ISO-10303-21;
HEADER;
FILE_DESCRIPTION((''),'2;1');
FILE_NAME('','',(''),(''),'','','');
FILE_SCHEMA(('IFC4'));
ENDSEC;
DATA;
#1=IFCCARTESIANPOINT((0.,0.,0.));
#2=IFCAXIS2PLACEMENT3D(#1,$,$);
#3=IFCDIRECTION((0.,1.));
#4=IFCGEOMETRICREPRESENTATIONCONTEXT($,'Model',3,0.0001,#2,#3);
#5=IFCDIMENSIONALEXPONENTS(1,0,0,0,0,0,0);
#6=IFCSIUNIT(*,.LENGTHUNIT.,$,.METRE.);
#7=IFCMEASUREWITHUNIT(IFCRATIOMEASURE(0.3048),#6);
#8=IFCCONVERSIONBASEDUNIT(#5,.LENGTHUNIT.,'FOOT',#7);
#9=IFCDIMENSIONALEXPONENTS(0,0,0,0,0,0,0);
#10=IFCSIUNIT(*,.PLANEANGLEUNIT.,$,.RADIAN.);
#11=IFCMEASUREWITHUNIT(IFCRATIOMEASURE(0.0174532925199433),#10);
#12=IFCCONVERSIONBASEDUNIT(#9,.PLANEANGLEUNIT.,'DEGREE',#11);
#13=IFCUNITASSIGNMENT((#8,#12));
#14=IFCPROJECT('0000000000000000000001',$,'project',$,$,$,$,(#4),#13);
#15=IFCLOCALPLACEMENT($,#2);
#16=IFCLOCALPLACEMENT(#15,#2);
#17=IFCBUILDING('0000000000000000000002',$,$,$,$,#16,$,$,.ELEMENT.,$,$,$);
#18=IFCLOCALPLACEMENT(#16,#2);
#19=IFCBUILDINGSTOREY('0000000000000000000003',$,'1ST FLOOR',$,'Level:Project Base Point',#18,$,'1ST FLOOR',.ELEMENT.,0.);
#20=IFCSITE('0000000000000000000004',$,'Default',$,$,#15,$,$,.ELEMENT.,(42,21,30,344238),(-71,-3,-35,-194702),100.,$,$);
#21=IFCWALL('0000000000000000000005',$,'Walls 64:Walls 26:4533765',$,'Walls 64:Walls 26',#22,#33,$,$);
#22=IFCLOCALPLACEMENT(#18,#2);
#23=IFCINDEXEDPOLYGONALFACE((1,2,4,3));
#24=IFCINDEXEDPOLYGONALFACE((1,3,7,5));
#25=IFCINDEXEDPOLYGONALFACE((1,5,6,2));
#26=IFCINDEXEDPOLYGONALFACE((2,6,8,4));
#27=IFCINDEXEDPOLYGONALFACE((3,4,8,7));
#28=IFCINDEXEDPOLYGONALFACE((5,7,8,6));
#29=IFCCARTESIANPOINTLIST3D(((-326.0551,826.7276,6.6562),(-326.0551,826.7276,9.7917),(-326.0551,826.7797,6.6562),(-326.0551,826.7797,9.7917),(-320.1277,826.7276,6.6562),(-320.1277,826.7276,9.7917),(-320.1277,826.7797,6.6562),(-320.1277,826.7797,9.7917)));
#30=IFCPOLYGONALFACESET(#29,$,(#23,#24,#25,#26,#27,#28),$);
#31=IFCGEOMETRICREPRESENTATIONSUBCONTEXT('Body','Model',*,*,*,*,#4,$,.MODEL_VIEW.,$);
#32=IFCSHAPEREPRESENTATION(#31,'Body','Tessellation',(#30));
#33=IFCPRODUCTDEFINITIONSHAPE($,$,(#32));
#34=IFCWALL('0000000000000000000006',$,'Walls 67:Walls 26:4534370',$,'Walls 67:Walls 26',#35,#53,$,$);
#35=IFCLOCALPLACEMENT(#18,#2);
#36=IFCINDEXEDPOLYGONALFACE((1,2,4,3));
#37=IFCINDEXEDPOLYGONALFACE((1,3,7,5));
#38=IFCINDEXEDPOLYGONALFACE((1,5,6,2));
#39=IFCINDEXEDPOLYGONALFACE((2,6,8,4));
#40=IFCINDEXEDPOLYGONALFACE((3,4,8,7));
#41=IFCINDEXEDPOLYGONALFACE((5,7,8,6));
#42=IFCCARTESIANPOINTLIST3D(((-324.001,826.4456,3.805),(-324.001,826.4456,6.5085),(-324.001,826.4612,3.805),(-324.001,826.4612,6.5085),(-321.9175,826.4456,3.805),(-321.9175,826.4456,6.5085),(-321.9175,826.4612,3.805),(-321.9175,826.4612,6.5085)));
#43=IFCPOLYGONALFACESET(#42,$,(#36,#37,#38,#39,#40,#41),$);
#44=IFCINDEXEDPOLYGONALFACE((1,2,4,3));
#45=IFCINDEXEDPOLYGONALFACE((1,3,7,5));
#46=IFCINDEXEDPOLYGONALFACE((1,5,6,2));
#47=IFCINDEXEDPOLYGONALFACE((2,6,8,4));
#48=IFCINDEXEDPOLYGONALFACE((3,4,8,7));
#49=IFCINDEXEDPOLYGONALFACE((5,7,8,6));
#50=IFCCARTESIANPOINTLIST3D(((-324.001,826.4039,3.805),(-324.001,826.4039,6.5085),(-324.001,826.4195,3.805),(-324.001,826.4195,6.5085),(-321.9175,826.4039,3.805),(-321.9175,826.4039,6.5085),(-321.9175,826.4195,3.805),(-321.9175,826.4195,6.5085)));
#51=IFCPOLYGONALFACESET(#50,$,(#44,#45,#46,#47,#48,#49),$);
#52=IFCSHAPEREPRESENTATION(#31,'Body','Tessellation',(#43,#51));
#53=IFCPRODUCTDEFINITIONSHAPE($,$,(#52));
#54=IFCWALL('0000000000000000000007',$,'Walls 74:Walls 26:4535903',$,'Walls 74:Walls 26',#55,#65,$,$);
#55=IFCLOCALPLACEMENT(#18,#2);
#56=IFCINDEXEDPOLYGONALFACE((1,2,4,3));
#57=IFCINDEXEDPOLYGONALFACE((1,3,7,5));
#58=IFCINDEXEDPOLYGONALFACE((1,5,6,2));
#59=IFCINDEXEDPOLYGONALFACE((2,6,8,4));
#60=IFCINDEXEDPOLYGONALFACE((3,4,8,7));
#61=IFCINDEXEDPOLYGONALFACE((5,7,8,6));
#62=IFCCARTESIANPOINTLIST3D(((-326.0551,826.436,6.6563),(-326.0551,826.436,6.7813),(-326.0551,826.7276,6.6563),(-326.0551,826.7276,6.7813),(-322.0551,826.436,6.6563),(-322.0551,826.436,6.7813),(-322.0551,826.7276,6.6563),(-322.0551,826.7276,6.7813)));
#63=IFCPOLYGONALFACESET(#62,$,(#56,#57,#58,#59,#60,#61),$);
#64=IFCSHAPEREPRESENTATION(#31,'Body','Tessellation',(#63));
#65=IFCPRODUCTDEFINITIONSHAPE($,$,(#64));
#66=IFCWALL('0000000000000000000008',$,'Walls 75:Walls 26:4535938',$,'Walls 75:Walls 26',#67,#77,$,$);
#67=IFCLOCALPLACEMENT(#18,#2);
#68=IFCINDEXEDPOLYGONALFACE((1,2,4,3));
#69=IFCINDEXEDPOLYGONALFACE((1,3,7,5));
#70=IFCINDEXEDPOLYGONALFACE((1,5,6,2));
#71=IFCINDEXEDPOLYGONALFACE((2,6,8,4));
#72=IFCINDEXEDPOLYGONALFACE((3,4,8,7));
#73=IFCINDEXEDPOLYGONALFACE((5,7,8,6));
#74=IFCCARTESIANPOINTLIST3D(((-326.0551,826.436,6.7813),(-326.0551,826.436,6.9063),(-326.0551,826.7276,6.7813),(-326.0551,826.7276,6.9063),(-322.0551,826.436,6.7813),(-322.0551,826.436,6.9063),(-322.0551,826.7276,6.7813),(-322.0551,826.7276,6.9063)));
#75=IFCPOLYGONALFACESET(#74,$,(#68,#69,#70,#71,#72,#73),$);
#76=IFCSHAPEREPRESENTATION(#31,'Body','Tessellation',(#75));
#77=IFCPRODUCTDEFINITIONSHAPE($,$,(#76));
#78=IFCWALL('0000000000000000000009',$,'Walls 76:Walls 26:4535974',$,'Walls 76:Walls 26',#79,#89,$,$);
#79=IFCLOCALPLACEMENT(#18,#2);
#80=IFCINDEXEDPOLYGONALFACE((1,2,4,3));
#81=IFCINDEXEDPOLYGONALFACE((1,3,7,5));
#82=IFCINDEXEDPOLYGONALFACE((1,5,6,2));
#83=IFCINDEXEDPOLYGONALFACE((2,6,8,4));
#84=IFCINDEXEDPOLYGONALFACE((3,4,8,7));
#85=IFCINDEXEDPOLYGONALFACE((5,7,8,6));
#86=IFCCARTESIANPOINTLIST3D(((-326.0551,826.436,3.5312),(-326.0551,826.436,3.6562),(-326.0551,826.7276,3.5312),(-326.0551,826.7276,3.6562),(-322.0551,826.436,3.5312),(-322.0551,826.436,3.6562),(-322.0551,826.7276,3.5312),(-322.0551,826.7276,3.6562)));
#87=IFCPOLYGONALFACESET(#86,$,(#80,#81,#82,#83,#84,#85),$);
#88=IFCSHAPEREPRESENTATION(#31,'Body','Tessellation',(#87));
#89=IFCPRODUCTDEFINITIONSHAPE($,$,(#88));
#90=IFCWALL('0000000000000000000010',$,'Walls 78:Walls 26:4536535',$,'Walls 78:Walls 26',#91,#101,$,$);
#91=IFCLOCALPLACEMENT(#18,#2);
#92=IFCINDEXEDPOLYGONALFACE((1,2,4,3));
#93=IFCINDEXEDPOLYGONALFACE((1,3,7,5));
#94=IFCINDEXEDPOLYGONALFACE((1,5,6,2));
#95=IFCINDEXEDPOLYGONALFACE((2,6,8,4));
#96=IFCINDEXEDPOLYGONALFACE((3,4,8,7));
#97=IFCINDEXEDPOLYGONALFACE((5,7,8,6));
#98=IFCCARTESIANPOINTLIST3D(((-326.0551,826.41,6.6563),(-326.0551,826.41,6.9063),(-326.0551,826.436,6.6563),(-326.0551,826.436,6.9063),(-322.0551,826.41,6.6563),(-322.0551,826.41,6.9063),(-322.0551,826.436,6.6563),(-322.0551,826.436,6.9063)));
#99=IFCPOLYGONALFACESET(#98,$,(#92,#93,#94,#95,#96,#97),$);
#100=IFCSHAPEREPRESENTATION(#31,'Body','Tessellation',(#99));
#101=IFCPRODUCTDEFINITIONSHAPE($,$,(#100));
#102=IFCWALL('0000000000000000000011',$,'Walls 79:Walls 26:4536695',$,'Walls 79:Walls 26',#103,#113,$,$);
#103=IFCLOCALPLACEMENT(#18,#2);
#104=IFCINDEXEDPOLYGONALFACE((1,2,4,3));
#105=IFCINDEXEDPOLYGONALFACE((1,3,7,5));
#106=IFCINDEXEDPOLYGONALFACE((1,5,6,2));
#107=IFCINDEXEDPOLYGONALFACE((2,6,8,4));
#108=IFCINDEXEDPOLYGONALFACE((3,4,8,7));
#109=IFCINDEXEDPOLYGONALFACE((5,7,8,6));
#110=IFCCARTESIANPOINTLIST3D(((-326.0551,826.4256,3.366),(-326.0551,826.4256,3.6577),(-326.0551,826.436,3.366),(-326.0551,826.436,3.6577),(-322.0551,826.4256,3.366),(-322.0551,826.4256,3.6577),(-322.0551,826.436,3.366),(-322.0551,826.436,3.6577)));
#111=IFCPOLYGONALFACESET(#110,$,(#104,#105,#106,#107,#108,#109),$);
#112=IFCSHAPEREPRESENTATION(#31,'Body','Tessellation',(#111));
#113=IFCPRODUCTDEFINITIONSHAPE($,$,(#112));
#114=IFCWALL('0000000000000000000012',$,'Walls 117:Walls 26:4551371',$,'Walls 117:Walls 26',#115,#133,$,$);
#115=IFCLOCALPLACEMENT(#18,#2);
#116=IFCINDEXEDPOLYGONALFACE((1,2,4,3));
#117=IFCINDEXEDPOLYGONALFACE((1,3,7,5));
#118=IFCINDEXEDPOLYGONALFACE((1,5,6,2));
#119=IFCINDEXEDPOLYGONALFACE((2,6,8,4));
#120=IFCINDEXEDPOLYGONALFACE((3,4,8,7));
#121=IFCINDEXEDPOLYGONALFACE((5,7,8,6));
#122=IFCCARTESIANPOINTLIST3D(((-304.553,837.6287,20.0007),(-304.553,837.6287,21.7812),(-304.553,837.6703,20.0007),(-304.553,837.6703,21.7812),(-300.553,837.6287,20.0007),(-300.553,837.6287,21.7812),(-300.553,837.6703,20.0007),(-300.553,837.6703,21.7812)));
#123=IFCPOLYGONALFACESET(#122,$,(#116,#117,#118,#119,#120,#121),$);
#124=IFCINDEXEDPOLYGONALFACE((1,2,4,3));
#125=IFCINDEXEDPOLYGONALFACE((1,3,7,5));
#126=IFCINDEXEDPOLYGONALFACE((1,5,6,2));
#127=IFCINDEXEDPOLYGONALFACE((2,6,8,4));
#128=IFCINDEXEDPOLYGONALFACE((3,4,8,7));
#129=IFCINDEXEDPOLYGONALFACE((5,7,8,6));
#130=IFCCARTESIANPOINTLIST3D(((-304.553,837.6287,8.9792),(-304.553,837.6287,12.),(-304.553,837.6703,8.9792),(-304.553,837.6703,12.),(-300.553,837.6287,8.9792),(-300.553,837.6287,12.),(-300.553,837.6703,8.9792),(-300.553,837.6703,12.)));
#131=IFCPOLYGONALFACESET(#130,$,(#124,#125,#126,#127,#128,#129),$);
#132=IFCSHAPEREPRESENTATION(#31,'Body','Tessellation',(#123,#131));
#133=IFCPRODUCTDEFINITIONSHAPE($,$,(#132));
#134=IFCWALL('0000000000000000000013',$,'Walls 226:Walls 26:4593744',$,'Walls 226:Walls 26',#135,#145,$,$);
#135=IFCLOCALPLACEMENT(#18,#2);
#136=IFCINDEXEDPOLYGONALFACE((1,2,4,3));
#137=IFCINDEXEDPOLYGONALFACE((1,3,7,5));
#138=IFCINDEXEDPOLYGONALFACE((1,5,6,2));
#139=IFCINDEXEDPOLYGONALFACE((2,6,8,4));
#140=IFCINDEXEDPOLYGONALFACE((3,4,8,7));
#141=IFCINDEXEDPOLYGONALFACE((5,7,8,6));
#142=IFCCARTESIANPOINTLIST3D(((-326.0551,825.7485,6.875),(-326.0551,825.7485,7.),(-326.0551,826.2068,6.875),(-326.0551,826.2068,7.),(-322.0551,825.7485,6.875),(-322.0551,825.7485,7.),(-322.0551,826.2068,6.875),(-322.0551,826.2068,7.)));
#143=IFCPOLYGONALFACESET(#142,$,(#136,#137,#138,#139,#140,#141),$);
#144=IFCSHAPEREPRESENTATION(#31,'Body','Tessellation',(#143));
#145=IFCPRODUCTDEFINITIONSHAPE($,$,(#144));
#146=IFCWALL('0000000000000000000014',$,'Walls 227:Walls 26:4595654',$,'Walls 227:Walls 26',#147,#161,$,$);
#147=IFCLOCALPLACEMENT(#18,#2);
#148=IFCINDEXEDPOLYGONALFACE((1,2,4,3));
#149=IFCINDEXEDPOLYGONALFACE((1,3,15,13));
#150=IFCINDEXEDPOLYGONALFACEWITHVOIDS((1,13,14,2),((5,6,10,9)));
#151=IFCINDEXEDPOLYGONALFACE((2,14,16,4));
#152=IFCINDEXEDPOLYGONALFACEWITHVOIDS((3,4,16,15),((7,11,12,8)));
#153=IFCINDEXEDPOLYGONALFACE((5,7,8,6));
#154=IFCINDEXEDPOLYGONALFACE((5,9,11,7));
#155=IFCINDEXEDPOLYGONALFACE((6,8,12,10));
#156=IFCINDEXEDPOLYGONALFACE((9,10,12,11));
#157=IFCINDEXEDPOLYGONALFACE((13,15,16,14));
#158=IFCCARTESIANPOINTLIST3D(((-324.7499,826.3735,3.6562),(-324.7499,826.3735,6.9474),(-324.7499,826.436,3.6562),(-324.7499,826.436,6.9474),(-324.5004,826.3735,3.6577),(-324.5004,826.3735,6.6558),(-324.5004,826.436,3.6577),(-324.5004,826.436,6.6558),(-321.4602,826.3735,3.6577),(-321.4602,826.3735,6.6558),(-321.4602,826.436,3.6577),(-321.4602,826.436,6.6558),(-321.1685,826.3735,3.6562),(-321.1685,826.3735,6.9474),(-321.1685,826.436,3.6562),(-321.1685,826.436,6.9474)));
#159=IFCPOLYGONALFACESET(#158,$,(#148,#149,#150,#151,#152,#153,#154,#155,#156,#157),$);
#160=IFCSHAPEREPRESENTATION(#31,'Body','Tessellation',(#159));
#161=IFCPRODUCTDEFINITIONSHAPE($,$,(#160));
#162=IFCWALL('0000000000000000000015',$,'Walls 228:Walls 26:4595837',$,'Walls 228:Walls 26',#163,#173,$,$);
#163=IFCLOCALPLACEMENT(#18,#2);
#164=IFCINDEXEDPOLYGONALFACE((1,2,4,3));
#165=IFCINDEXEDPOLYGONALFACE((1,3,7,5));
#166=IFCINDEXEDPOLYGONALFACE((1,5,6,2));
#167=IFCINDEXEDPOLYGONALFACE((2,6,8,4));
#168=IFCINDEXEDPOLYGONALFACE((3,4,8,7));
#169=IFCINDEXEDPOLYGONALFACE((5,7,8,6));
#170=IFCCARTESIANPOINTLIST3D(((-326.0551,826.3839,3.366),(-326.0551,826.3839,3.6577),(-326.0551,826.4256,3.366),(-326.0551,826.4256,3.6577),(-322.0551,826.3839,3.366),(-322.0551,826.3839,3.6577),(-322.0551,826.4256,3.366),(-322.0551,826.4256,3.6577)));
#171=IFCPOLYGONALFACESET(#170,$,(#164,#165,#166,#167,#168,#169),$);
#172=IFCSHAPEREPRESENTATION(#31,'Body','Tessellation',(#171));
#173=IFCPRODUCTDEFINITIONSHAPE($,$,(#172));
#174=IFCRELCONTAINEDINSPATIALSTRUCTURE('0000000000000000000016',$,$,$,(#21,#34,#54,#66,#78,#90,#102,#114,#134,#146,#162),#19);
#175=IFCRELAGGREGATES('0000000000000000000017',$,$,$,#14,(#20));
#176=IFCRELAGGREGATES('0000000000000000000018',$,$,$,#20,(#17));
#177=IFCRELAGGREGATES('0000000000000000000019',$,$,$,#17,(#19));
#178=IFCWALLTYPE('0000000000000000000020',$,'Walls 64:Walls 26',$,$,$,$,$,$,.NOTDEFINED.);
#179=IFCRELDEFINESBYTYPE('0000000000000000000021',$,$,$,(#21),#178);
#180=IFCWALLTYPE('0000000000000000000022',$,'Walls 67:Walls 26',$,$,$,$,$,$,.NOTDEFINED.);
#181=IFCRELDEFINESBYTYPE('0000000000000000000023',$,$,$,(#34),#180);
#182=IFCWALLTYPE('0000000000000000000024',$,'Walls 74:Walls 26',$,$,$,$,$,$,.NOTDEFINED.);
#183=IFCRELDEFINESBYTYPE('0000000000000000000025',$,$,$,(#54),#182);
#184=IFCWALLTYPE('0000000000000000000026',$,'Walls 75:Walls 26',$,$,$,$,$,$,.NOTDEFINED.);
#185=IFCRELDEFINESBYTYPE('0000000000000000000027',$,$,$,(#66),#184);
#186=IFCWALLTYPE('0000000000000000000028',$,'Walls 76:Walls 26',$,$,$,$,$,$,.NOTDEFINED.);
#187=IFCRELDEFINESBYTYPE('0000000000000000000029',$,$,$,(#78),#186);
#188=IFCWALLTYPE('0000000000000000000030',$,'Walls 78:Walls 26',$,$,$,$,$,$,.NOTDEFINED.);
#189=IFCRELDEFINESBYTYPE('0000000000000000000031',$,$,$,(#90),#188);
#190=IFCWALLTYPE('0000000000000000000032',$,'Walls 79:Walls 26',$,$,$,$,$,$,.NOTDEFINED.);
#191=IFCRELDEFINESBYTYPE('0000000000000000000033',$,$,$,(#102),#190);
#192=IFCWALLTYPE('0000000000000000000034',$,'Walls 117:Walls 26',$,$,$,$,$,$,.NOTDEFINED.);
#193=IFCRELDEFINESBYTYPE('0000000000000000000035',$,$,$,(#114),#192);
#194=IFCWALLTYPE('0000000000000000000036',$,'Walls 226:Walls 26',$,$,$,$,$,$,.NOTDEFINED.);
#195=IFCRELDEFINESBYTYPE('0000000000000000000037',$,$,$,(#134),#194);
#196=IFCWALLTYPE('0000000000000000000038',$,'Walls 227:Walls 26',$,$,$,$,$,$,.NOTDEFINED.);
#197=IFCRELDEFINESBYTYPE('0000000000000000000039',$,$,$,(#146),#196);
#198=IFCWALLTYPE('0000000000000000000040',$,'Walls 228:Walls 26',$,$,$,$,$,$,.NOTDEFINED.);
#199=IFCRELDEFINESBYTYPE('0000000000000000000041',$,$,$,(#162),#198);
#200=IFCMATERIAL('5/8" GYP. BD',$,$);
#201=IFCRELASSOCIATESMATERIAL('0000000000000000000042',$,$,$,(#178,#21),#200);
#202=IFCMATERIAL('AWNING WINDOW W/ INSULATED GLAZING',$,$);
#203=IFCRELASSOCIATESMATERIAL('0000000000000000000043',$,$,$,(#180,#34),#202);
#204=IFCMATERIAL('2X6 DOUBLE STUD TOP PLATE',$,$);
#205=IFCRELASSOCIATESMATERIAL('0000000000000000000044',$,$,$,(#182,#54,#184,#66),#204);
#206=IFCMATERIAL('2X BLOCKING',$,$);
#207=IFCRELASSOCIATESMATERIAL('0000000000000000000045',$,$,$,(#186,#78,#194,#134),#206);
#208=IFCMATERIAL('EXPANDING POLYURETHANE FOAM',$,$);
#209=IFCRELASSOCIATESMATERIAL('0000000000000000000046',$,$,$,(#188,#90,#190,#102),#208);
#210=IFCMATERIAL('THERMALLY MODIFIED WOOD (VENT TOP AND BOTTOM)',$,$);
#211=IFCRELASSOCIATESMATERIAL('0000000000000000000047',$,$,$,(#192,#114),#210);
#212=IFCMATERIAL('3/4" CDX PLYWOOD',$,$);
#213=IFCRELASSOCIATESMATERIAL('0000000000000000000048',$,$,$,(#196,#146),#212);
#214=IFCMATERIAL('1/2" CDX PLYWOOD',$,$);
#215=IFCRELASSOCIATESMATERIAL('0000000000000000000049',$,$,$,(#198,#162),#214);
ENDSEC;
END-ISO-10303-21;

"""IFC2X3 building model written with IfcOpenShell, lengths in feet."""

from ifc_helpers import new_model, entity, si_unit, converted_unit, direction, frame, frame_2d, origin, origin_2d_with_axis, place, context, subcontext, project, spatial, rectangle, extrude, material, type_object, element, save


model = new_model("IFC2X3")

# Units and contexts
model_context = context("Model", 3, precision=0.0001, world=origin(), true_north=direction((0.0, 1.0)))
body_context = subcontext(model_context, "Body", "Model", "MODEL_VIEW")
ifc_project = project(units=[converted_unit("LENGTHUNIT", "FOOT", entity("IfcRatioMeasure", 0.3048), si_unit("LENGTHUNIT", "METRE"), dimensions=[1, 0, 0, 0, 0, 0, 0]), converted_unit("PLANEANGLEUNIT", "DEGREE", entity("IfcRatioMeasure", 0.0174532925199433), si_unit("PLANEANGLEUNIT", "RADIAN"), dimensions=[0, 0, 0, 0, 0, 0, 0])], contexts=[model_context])

# Site, building, storey
site_placement = place(None, origin())
site = spatial("IfcSite", under=ifc_project, at=site_placement, Name="Default", CompositionType="ELEMENT", RefLatitude=(42, 21, 30, 344238), RefLongitude=(-71, -3, -35, -194702), RefElevation=100.0)
building_placement = place(site_placement, origin())
building = spatial("IfcBuilding", under=site, at=building_placement, CompositionType="ELEMENT")
storey_placement = place(building_placement, origin())
storey = spatial("IfcBuildingStorey", under=building, at=storey_placement, Name="1ST FLOOR", ObjectType="Level:Project Base Point", LongName="1ST FLOOR", CompositionType="ELEMENT", Elevation=0.0)

# Wall
ifc_material_1 = material(Name="5/8\" GYP. BD")
wall_type_1 = type_object("IfcWallType", Name="Walls 64:Walls 26", PredefinedType="NOTDEFINED", material=ifc_material_1)
wall_1_placement = place(storey_placement, frame((-326.0551, 826.7276, 6.6562)))
element("IfcWall", 1, at=wall_1_placement, inside=storey, type_object=wall_type_1, material=ifc_material_1, Name="Walls 64:Walls 26:4533765", ObjectType="Walls 64:Walls 26", context=body_context, shape_type="SweptSolid", body=[
    extrude(rectangle(XDim=5.9274, YDim=0.0521, at=frame_2d((0.0, 0.0), x_axis=(1.0, 0.0))), frame((2.9637, 0.026, 0.0), z_axis=(0.0, 0.0, 1.0), x_axis=(-1.0, 0.0, 0.0)), (0.0, 0.0, 1.0), 3.1354),
])

# Shared definitions
ifc_material_2 = material(Name="THERMALLY MODIFIED WOOD (VENT TOP AND BOTTOM)")

# Walls
ifc_material_3 = material(Name="AWNING WINDOW W/ INSULATED GLAZING")
wall_type_2 = type_object("IfcWallType", Name="Walls 67:Walls 26", PredefinedType="NOTDEFINED", material=ifc_material_3)
wall_2_placement = place(storey_placement, frame((-324.001, 826.4039, 3.805)))
element("IfcWall", 2, at=wall_2_placement, inside=storey, type_object=wall_type_2, material=ifc_material_3, Name="Walls 67:Walls 26:4534370", ObjectType="Walls 67:Walls 26", context=body_context, shape_type="SweptSolid", body=[
    extrude(rectangle(XDim=2.0835, YDim=0.0156, at=origin_2d_with_axis()), frame((1.0418, 0.0495, 0.0), z_axis=(0.0, 0.0, 1.0), x_axis=(-1.0, 0.0, 0.0)), (0.0, 0.0, 1.0), 2.7035),
    extrude(rectangle(XDim=2.0835, YDim=0.0156, at=origin_2d_with_axis()), frame((1.0418, 0.0078, 0.0), z_axis=(0.0, 0.0, 1.0), x_axis=(-1.0, 0.0, 0.0)), (0.0, 0.0, 1.0), 2.7035),
])
ifc_material_4 = material(Name="2X6 DOUBLE STUD TOP PLATE")
wall_type_3 = type_object("IfcWallType", Name="Walls 74:Walls 26", PredefinedType="NOTDEFINED", material=ifc_material_4)
wall_3_placement = place(storey_placement, frame((-326.0551, 826.436, 6.6563)))
element("IfcWall", 3, at=wall_3_placement, inside=storey, type_object=wall_type_3, material=ifc_material_4, Name="Walls 74:Walls 26:4535903", ObjectType="Walls 74:Walls 26", context=body_context, shape_type="SweptSolid", body=[
    extrude(rectangle(XDim=4.0, YDim=0.2917, at=origin_2d_with_axis()), frame((2.0, 0.1458, 0.0), z_axis=(0.0, 0.0, 1.0), x_axis=(-1.0, 0.0, 0.0)), (0.0, 0.0, 1.0), 0.125),
])
wall_type_4 = type_object("IfcWallType", Name="Walls 75:Walls 26", PredefinedType="NOTDEFINED", material=ifc_material_4)
wall_4_placement = place(storey_placement, frame((-326.0551, 826.436, 6.7813)))
element("IfcWall", 4, at=wall_4_placement, inside=storey, type_object=wall_type_4, material=ifc_material_4, Name="Walls 75:Walls 26:4535938", ObjectType="Walls 75:Walls 26", context=body_context, shape_type="SweptSolid", body=[
    extrude(rectangle(XDim=4.0, YDim=0.2917, at=origin_2d_with_axis()), frame((2.0, 0.1458, 0.0), z_axis=(0.0, 0.0, 1.0), x_axis=(-1.0, 0.0, 0.0)), (0.0, 0.0, 1.0), 0.125),
])
ifc_material_5 = material(Name="2X BLOCKING")
wall_type_5 = type_object("IfcWallType", Name="Walls 76:Walls 26", PredefinedType="NOTDEFINED", material=ifc_material_5)
wall_5_placement = place(storey_placement, frame((-326.0551, 826.436, 3.5312)))
element("IfcWall", 5, at=wall_5_placement, inside=storey, type_object=wall_type_5, material=ifc_material_5, Name="Walls 76:Walls 26:4535974", ObjectType="Walls 76:Walls 26", context=body_context, shape_type="SweptSolid", body=[
    extrude(rectangle(XDim=4.0, YDim=0.2917, at=origin_2d_with_axis()), frame((2.0, 0.1458, 0.0), z_axis=(0.0, 0.0, 1.0), x_axis=(-1.0, 0.0, 0.0)), (0.0, 0.0, 1.0), 0.125),
])
ifc_material_6 = material(Name="EXPANDING POLYURETHANE FOAM")
wall_type_6 = type_object("IfcWallType", Name="Walls 78:Walls 26", PredefinedType="NOTDEFINED", material=ifc_material_6)
wall_6_placement = place(storey_placement, frame((-326.0551, 826.41, 6.6563)))
element("IfcWall", 6, at=wall_6_placement, inside=storey, type_object=wall_type_6, material=ifc_material_6, Name="Walls 78:Walls 26:4536535", ObjectType="Walls 78:Walls 26", context=body_context, shape_type="SweptSolid", body=[
    extrude(rectangle(XDim=4.0, YDim=0.026, at=origin_2d_with_axis()), frame((2.0, 0.013, 0.0), z_axis=(0.0, 0.0, 1.0), x_axis=(-1.0, 0.0, 0.0)), (0.0, 0.0, 1.0), 0.25),
])
wall_type_7 = type_object("IfcWallType", Name="Walls 79:Walls 26", PredefinedType="NOTDEFINED", material=ifc_material_6)
wall_7_placement = place(storey_placement, frame((-326.0551, 826.4256, 3.366)))
element("IfcWall", 7, at=wall_7_placement, inside=storey, type_object=wall_type_7, material=ifc_material_6, Name="Walls 79:Walls 26:4536695", ObjectType="Walls 79:Walls 26", context=body_context, shape_type="SweptSolid", body=[
    extrude(rectangle(XDim=4.0, YDim=0.0104, at=origin_2d_with_axis()), frame((2.0, 0.0052, 0.0), z_axis=(0.0, 0.0, 1.0), x_axis=(-1.0, 0.0, 0.0)), (0.0, 0.0, 1.0), 0.2917),
])
wall_type_8 = type_object("IfcWallType", Name="Walls 117:Walls 26", PredefinedType="NOTDEFINED", material=ifc_material_2)
wall_8_placement = place(storey_placement, frame((-304.553, 837.6287, 8.9792)))
element("IfcWall", 8, at=wall_8_placement, inside=storey, type_object=wall_type_8, material=ifc_material_2, Name="Walls 117:Walls 26:4551371", ObjectType="Walls 117:Walls 26", context=body_context, shape_type="SweptSolid", body=[
    extrude(rectangle(XDim=4.0, YDim=0.0417, at=frame_2d((0.0, 0.0), x_axis=(1.0, 0.0))), frame((2.0, 0.0208, 11.0215), z_axis=(0.0, 0.0, 1.0), x_axis=(-1.0, 0.0, 0.0)), (0.0, 0.0, 1.0), 1.7806),
    extrude(rectangle(XDim=4.0, YDim=0.0417, at=frame_2d((0.0, 0.0), x_axis=(1.0, 0.0))), frame((2.0, 0.0208, 0.0), z_axis=(0.0, 0.0, 1.0), x_axis=(-1.0, 0.0, 0.0)), (0.0, 0.0, 1.0), 3.0208),
])
wall_type_9 = type_object("IfcWallType", Name="Walls 226:Walls 26", PredefinedType="NOTDEFINED", material=ifc_material_5)
wall_9_placement = place(storey_placement, frame((-326.0551, 825.7485, 6.875)))
element("IfcWall", 9, at=wall_9_placement, inside=storey, type_object=wall_type_9, material=ifc_material_5, Name="Walls 226:Walls 26:4593744", ObjectType="Walls 226:Walls 26", context=body_context, shape_type="SweptSolid", body=[
    extrude(rectangle(XDim=4.0, YDim=0.4583, at=frame_2d((0.0, 0.0), x_axis=(1.0, 0.0))), frame((2.0, 0.2292, 0.0), z_axis=(0.0, 0.0, 1.0), x_axis=(-1.0, 0.0, 0.0)), (0.0, 0.0, 1.0), 0.125),
])

# Wall, opening
ifc_material_7 = material(Name="3/4\" CDX PLYWOOD")
wall_type_10 = type_object("IfcWallType", Name="Walls 227:Walls 26", PredefinedType="NOTDEFINED", material=ifc_material_7)
wall_10_placement = place(storey_placement, frame((-324.7499, 826.3735, 3.6562)))
wall_10 = element("IfcWall", 10, at=wall_10_placement, inside=storey, type_object=wall_type_10, material=ifc_material_7, Name="Walls 227:Walls 26:4595654", ObjectType="Walls 227:Walls 26", context=body_context, shape_type="SweptSolid", body=[
    extrude(rectangle(XDim=3.5814, YDim=0.0625, at=frame_2d((0.0, 0.0), x_axis=(1.0, 0.0))), frame((1.7907, 0.0312, 0.0), z_axis=(0.0, 0.0, 1.0), x_axis=(-1.0, 0.0, 0.0)), (0.0, 0.0, 1.0), 3.2912),
])
opening_1_placement = place(storey_placement, frame((-324.7499, 826.3735, 3.6562)))
element("IfcOpeningElement", 11, at=opening_1_placement, cuts=wall_10, ObjectType="Opening", context=body_context, shape_type="SweptSolid", body=[
    extrude(rectangle(XDim=2.9981, YDim=3.0402, at=frame_2d((0.0, 0.0), x_axis=(0.0, 1.0))), frame((1.7696, 0.0625, 1.5005), z_axis=(0.0, -1.0, 0.0), x_axis=(-1.0, 0.0, 0.0)), (0.0, 0.0, 1.0), 0.0625),
])

# Wall
ifc_material_8 = material(Name="1/2\" CDX PLYWOOD")
wall_type_11 = type_object("IfcWallType", Name="Walls 228:Walls 26", PredefinedType="NOTDEFINED", material=ifc_material_8)
wall_11_placement = place(storey_placement, frame((-326.0551, 826.3839, 3.366)))
element("IfcWall", 12, at=wall_11_placement, inside=storey, type_object=wall_type_11, material=ifc_material_8, Name="Walls 228:Walls 26:4595837", ObjectType="Walls 228:Walls 26", context=body_context, shape_type="SweptSolid", body=[
    extrude(rectangle(XDim=4.0, YDim=0.0417, at=frame_2d((0.0, 0.0), x_axis=(1.0, 0.0))), frame((2.0, 0.0208, 0.0), z_axis=(0.0, 0.0, 1.0), x_axis=(-1.0, 0.0, 0.0)), (0.0, 0.0, 1.0), 0.2917),
])

save(model, "model.ifc")
